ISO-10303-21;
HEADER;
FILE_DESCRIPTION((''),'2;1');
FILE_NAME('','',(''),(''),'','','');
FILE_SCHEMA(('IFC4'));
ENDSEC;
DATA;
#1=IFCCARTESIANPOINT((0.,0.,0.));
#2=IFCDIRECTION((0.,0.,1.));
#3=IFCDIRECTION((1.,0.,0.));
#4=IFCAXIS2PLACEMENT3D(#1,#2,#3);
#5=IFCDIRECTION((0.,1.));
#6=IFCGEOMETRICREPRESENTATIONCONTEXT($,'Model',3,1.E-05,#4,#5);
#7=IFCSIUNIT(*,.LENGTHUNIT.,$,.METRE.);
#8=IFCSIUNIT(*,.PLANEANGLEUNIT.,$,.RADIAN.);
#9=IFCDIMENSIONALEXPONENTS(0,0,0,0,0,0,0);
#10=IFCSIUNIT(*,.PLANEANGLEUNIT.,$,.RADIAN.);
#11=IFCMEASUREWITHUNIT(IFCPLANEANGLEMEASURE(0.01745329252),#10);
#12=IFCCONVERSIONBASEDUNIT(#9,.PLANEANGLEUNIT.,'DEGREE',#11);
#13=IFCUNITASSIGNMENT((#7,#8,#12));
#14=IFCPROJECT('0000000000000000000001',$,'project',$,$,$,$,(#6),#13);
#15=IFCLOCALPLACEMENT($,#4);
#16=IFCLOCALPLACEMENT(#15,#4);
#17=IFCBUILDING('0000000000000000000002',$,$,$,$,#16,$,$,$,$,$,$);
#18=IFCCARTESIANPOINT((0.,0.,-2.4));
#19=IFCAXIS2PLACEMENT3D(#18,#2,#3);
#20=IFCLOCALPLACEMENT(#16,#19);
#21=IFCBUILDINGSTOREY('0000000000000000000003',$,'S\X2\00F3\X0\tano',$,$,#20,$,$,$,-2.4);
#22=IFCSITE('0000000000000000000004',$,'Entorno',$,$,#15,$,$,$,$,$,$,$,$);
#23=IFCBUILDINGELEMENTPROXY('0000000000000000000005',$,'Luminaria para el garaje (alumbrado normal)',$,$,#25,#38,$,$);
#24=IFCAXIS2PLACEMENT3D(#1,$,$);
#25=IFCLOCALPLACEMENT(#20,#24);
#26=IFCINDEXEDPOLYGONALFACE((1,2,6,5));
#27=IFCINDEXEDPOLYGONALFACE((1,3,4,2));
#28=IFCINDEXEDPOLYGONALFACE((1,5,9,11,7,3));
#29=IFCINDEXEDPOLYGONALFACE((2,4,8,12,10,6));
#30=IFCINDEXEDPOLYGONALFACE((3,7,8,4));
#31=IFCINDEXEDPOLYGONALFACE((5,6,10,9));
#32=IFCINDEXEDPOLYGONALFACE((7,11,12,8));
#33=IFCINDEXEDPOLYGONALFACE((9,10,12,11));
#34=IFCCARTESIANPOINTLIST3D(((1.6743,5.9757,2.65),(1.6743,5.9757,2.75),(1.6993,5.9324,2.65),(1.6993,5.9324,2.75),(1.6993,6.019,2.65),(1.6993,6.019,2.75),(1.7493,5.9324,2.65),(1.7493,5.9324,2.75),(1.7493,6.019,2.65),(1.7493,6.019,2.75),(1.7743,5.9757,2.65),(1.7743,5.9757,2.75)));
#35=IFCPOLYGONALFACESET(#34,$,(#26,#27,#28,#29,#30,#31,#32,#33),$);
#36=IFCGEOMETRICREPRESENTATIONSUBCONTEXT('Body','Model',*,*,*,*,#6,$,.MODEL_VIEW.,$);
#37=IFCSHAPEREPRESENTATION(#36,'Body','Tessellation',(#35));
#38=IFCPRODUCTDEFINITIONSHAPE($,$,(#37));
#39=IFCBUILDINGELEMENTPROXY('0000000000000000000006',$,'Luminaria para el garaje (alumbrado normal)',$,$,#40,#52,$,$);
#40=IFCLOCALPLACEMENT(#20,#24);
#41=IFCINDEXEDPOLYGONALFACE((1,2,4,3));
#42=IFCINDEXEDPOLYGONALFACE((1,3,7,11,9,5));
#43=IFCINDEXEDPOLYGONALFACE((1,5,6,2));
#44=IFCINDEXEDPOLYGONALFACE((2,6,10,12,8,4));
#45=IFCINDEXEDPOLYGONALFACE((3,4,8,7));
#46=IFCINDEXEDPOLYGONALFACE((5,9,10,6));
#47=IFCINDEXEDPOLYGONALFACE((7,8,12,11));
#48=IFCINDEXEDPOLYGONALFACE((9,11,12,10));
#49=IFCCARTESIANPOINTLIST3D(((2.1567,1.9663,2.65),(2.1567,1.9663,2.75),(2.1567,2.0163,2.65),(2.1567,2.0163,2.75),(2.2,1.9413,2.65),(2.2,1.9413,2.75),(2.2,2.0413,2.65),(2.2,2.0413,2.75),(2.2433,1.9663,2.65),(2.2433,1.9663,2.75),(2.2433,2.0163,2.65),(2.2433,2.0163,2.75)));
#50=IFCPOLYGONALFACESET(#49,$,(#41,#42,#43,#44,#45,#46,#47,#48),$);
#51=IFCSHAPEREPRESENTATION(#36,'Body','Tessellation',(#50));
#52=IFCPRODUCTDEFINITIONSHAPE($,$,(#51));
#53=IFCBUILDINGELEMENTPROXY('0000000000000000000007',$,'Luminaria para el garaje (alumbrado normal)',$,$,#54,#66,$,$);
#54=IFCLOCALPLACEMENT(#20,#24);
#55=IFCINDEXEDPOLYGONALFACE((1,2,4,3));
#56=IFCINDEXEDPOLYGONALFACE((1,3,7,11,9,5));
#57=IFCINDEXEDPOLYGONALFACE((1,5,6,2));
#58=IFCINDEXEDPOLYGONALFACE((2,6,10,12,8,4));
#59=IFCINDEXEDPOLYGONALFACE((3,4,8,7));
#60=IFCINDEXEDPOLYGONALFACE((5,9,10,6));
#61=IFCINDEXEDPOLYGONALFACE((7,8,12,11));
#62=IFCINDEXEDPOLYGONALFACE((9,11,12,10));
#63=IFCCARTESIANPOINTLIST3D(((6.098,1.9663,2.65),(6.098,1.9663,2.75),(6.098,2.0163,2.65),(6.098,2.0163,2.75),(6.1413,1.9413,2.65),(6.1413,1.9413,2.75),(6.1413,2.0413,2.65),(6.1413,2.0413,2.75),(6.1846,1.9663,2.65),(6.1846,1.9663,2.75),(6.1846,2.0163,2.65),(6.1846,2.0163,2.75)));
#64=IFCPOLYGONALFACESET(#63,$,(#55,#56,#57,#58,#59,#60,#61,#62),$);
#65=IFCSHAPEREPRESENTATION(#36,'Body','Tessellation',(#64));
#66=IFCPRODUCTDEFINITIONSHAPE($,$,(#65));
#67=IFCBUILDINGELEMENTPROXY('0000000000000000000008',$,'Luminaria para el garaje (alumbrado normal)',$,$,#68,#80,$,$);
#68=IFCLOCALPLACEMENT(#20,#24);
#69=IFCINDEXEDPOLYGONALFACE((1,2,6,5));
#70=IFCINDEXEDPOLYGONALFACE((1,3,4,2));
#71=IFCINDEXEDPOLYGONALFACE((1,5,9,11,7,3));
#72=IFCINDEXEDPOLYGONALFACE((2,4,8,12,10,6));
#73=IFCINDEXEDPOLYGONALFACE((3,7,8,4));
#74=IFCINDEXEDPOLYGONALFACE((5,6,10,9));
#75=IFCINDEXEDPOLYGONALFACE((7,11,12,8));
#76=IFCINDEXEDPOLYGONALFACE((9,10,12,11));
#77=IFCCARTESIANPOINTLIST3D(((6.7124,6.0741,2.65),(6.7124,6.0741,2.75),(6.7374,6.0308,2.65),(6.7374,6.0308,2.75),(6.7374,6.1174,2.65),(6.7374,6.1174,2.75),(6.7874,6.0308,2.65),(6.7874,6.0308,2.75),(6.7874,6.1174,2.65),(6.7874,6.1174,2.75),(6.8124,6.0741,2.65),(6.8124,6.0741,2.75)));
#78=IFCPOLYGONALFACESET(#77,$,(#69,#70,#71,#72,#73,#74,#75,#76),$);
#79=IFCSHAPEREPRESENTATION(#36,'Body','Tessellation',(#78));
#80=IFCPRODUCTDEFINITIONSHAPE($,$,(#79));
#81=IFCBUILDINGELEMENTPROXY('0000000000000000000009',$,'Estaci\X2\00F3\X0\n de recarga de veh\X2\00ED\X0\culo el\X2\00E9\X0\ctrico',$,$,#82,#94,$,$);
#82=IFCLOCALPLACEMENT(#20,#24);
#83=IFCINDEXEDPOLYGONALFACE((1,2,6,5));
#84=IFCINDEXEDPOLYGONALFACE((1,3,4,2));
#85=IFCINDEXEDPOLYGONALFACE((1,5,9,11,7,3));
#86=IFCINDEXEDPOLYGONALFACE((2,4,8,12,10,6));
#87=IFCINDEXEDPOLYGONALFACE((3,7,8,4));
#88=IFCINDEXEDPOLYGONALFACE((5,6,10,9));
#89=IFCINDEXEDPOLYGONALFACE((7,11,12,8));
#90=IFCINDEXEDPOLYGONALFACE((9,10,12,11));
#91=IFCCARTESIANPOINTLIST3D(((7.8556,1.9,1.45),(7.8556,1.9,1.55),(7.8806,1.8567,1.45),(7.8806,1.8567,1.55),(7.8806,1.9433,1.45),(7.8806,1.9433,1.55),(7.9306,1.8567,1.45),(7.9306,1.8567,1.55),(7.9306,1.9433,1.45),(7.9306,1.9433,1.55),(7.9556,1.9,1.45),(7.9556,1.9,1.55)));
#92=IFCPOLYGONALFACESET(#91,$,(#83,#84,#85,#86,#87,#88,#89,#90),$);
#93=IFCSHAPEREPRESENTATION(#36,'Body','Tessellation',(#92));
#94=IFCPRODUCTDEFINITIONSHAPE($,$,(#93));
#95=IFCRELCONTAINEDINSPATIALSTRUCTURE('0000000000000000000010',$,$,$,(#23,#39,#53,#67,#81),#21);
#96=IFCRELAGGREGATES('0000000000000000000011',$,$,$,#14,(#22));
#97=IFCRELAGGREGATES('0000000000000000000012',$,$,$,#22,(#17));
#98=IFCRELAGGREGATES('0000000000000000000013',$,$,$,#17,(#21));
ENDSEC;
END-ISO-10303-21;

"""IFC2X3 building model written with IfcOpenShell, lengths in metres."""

from ifc_helpers import new_model, entity, si_unit, converted_unit, direction, frame, origin_with_axes, place, context, subcontext, project, spatial, polyline, outline, extrude, source, transform, mapped, element, save


model = new_model("IFC2X3")

# Units and contexts
model_context = context("Model", 3, precision=1e-05, world=origin_with_axes(), true_north=direction((0.0, 1.0)))
body_context = subcontext(model_context, "Body", "Model", "MODEL_VIEW")
ifc_project = project(units=[si_unit("LENGTHUNIT", "METRE"), si_unit("PLANEANGLEUNIT", "RADIAN"), converted_unit("PLANEANGLEUNIT", "DEGREE", entity("IfcPlaneAngleMeasure", 0.01745329252), si_unit("PLANEANGLEUNIT", "RADIAN"), dimensions=[0, 0, 0, 0, 0, 0, 0])], contexts=[model_context])

# Site, building, storey
site_placement = place(None, origin_with_axes())
site = spatial("IfcSite", under=ifc_project, at=site_placement, Name="Entorno")
building_placement = place(site_placement, origin_with_axes())
building = spatial("IfcBuilding", under=site, at=building_placement)
storey_placement = place(building_placement, frame((0.0, 0.0, -2.4), z_axis=(0.0, 0.0, 1.0), x_axis=(1.0, 0.0, 0.0)))
storey = spatial("IfcBuildingStorey", under=building, at=storey_placement, Name="Sótano", Elevation=-2.4)

# Building element proxies
shared_shape_1 = source(origin_with_axes(), body_context, "Body", "SolidModel", [
    extrude(outline(polyline([(0.05, 0.0), (0.025, 0.0433), (-0.025, 0.0433), (-0.05, 0.0), (-0.025, -0.0433), (0.025, -0.0433), (0.05, 0.0)])), frame((0.0, 0.0, -0.05), z_axis=(0.0, 0.0, 1.0), x_axis=(1.0, 0.0, 0.0)), (0.0, 0.0, 1.0), 0.1),
])
proxy_1_placement = place(storey_placement, frame((0.0, 0.0, 2.4), z_axis=(0.0, 0.0, 1.0), x_axis=(1.0, 0.0, 0.0)))
element("IfcBuildingElementProxy", 1, at=proxy_1_placement, inside=storey, Name="Luminaria para el garaje (alumbrado normal)", context=body_context, shape_type="Brep", body=[
    mapped(shared_shape_1, transform((1.7243, 5.9757, 0.3), x_axis=(1.0, 0.0, 0.0), y_axis=(0.0, 1.0, 0.0), z_axis=(0.0, 0.0, 1.0))),
])
proxy_2_placement = place(storey_placement, frame((0.0, 0.0, 2.4), z_axis=(0.0, 0.0, 1.0), x_axis=(1.0, 0.0, 0.0)))
element("IfcBuildingElementProxy", 2, at=proxy_2_placement, inside=storey, Name="Luminaria para el garaje (alumbrado normal)", context=body_context, shape_type="Brep", body=[
    mapped(shared_shape_1, transform((2.2, 1.9913, 0.3), x_axis=(0.0, 1.0, 0.0), y_axis=(-1.0, 0.0, 0.0), z_axis=(0.0, 0.0, 1.0))),
])
proxy_3_placement = place(storey_placement, frame((0.0, 0.0, 2.4), z_axis=(0.0, 0.0, 1.0), x_axis=(1.0, 0.0, 0.0)))
element("IfcBuildingElementProxy", 3, at=proxy_3_placement, inside=storey, Name="Luminaria para el garaje (alumbrado normal)", context=body_context, shape_type="Brep", body=[
    mapped(shared_shape_1, transform((6.1413, 1.9913, 0.3), x_axis=(0.0, 1.0, 0.0), y_axis=(-1.0, 0.0, 0.0), z_axis=(0.0, 0.0, 1.0))),
])
proxy_4_placement = place(storey_placement, frame((0.0, 0.0, 2.4), z_axis=(0.0, 0.0, 1.0), x_axis=(1.0, 0.0, 0.0)))
element("IfcBuildingElementProxy", 4, at=proxy_4_placement, inside=storey, Name="Luminaria para el garaje (alumbrado normal)", context=body_context, shape_type="Brep", body=[
    mapped(shared_shape_1, transform((6.7623, 6.0741, 0.3), x_axis=(-1.0, 0.0, 0.0), y_axis=(0.0, -1.0, 0.0), z_axis=(0.0, 0.0, 1.0))),
])
shared_shape_2 = source(origin_with_axes(), body_context, "Body", "SolidModel", [
    extrude(outline(polyline([(0.05, 0.0), (0.025, 0.0433), (-0.025, 0.0433), (-0.05, 0.0), (-0.025, -0.0433), (0.025, -0.0433), (0.05, 0.0)])), frame((0.0, 0.0, -0.05), z_axis=(0.0, 0.0, 1.0), x_axis=(1.0, 0.0, 0.0)), (0.0, 0.0, 1.0), 0.1),
])
proxy_5_placement = place(storey_placement, frame((0.0, 0.0, 2.4), z_axis=(0.0, 0.0, 1.0), x_axis=(1.0, 0.0, 0.0)))
element("IfcBuildingElementProxy", 5, at=proxy_5_placement, inside=storey, Name="Estación de recarga de vehículo eléctrico", context=body_context, shape_type="Brep", body=[
    mapped(shared_shape_2, transform((7.9056, 1.9, -0.9), x_axis=(1.0, 0.0, 0.0), y_axis=(0.0, 1.0, 0.0), z_axis=(0.0, 0.0, 1.0))),
])

save(model, "model.ifc")
